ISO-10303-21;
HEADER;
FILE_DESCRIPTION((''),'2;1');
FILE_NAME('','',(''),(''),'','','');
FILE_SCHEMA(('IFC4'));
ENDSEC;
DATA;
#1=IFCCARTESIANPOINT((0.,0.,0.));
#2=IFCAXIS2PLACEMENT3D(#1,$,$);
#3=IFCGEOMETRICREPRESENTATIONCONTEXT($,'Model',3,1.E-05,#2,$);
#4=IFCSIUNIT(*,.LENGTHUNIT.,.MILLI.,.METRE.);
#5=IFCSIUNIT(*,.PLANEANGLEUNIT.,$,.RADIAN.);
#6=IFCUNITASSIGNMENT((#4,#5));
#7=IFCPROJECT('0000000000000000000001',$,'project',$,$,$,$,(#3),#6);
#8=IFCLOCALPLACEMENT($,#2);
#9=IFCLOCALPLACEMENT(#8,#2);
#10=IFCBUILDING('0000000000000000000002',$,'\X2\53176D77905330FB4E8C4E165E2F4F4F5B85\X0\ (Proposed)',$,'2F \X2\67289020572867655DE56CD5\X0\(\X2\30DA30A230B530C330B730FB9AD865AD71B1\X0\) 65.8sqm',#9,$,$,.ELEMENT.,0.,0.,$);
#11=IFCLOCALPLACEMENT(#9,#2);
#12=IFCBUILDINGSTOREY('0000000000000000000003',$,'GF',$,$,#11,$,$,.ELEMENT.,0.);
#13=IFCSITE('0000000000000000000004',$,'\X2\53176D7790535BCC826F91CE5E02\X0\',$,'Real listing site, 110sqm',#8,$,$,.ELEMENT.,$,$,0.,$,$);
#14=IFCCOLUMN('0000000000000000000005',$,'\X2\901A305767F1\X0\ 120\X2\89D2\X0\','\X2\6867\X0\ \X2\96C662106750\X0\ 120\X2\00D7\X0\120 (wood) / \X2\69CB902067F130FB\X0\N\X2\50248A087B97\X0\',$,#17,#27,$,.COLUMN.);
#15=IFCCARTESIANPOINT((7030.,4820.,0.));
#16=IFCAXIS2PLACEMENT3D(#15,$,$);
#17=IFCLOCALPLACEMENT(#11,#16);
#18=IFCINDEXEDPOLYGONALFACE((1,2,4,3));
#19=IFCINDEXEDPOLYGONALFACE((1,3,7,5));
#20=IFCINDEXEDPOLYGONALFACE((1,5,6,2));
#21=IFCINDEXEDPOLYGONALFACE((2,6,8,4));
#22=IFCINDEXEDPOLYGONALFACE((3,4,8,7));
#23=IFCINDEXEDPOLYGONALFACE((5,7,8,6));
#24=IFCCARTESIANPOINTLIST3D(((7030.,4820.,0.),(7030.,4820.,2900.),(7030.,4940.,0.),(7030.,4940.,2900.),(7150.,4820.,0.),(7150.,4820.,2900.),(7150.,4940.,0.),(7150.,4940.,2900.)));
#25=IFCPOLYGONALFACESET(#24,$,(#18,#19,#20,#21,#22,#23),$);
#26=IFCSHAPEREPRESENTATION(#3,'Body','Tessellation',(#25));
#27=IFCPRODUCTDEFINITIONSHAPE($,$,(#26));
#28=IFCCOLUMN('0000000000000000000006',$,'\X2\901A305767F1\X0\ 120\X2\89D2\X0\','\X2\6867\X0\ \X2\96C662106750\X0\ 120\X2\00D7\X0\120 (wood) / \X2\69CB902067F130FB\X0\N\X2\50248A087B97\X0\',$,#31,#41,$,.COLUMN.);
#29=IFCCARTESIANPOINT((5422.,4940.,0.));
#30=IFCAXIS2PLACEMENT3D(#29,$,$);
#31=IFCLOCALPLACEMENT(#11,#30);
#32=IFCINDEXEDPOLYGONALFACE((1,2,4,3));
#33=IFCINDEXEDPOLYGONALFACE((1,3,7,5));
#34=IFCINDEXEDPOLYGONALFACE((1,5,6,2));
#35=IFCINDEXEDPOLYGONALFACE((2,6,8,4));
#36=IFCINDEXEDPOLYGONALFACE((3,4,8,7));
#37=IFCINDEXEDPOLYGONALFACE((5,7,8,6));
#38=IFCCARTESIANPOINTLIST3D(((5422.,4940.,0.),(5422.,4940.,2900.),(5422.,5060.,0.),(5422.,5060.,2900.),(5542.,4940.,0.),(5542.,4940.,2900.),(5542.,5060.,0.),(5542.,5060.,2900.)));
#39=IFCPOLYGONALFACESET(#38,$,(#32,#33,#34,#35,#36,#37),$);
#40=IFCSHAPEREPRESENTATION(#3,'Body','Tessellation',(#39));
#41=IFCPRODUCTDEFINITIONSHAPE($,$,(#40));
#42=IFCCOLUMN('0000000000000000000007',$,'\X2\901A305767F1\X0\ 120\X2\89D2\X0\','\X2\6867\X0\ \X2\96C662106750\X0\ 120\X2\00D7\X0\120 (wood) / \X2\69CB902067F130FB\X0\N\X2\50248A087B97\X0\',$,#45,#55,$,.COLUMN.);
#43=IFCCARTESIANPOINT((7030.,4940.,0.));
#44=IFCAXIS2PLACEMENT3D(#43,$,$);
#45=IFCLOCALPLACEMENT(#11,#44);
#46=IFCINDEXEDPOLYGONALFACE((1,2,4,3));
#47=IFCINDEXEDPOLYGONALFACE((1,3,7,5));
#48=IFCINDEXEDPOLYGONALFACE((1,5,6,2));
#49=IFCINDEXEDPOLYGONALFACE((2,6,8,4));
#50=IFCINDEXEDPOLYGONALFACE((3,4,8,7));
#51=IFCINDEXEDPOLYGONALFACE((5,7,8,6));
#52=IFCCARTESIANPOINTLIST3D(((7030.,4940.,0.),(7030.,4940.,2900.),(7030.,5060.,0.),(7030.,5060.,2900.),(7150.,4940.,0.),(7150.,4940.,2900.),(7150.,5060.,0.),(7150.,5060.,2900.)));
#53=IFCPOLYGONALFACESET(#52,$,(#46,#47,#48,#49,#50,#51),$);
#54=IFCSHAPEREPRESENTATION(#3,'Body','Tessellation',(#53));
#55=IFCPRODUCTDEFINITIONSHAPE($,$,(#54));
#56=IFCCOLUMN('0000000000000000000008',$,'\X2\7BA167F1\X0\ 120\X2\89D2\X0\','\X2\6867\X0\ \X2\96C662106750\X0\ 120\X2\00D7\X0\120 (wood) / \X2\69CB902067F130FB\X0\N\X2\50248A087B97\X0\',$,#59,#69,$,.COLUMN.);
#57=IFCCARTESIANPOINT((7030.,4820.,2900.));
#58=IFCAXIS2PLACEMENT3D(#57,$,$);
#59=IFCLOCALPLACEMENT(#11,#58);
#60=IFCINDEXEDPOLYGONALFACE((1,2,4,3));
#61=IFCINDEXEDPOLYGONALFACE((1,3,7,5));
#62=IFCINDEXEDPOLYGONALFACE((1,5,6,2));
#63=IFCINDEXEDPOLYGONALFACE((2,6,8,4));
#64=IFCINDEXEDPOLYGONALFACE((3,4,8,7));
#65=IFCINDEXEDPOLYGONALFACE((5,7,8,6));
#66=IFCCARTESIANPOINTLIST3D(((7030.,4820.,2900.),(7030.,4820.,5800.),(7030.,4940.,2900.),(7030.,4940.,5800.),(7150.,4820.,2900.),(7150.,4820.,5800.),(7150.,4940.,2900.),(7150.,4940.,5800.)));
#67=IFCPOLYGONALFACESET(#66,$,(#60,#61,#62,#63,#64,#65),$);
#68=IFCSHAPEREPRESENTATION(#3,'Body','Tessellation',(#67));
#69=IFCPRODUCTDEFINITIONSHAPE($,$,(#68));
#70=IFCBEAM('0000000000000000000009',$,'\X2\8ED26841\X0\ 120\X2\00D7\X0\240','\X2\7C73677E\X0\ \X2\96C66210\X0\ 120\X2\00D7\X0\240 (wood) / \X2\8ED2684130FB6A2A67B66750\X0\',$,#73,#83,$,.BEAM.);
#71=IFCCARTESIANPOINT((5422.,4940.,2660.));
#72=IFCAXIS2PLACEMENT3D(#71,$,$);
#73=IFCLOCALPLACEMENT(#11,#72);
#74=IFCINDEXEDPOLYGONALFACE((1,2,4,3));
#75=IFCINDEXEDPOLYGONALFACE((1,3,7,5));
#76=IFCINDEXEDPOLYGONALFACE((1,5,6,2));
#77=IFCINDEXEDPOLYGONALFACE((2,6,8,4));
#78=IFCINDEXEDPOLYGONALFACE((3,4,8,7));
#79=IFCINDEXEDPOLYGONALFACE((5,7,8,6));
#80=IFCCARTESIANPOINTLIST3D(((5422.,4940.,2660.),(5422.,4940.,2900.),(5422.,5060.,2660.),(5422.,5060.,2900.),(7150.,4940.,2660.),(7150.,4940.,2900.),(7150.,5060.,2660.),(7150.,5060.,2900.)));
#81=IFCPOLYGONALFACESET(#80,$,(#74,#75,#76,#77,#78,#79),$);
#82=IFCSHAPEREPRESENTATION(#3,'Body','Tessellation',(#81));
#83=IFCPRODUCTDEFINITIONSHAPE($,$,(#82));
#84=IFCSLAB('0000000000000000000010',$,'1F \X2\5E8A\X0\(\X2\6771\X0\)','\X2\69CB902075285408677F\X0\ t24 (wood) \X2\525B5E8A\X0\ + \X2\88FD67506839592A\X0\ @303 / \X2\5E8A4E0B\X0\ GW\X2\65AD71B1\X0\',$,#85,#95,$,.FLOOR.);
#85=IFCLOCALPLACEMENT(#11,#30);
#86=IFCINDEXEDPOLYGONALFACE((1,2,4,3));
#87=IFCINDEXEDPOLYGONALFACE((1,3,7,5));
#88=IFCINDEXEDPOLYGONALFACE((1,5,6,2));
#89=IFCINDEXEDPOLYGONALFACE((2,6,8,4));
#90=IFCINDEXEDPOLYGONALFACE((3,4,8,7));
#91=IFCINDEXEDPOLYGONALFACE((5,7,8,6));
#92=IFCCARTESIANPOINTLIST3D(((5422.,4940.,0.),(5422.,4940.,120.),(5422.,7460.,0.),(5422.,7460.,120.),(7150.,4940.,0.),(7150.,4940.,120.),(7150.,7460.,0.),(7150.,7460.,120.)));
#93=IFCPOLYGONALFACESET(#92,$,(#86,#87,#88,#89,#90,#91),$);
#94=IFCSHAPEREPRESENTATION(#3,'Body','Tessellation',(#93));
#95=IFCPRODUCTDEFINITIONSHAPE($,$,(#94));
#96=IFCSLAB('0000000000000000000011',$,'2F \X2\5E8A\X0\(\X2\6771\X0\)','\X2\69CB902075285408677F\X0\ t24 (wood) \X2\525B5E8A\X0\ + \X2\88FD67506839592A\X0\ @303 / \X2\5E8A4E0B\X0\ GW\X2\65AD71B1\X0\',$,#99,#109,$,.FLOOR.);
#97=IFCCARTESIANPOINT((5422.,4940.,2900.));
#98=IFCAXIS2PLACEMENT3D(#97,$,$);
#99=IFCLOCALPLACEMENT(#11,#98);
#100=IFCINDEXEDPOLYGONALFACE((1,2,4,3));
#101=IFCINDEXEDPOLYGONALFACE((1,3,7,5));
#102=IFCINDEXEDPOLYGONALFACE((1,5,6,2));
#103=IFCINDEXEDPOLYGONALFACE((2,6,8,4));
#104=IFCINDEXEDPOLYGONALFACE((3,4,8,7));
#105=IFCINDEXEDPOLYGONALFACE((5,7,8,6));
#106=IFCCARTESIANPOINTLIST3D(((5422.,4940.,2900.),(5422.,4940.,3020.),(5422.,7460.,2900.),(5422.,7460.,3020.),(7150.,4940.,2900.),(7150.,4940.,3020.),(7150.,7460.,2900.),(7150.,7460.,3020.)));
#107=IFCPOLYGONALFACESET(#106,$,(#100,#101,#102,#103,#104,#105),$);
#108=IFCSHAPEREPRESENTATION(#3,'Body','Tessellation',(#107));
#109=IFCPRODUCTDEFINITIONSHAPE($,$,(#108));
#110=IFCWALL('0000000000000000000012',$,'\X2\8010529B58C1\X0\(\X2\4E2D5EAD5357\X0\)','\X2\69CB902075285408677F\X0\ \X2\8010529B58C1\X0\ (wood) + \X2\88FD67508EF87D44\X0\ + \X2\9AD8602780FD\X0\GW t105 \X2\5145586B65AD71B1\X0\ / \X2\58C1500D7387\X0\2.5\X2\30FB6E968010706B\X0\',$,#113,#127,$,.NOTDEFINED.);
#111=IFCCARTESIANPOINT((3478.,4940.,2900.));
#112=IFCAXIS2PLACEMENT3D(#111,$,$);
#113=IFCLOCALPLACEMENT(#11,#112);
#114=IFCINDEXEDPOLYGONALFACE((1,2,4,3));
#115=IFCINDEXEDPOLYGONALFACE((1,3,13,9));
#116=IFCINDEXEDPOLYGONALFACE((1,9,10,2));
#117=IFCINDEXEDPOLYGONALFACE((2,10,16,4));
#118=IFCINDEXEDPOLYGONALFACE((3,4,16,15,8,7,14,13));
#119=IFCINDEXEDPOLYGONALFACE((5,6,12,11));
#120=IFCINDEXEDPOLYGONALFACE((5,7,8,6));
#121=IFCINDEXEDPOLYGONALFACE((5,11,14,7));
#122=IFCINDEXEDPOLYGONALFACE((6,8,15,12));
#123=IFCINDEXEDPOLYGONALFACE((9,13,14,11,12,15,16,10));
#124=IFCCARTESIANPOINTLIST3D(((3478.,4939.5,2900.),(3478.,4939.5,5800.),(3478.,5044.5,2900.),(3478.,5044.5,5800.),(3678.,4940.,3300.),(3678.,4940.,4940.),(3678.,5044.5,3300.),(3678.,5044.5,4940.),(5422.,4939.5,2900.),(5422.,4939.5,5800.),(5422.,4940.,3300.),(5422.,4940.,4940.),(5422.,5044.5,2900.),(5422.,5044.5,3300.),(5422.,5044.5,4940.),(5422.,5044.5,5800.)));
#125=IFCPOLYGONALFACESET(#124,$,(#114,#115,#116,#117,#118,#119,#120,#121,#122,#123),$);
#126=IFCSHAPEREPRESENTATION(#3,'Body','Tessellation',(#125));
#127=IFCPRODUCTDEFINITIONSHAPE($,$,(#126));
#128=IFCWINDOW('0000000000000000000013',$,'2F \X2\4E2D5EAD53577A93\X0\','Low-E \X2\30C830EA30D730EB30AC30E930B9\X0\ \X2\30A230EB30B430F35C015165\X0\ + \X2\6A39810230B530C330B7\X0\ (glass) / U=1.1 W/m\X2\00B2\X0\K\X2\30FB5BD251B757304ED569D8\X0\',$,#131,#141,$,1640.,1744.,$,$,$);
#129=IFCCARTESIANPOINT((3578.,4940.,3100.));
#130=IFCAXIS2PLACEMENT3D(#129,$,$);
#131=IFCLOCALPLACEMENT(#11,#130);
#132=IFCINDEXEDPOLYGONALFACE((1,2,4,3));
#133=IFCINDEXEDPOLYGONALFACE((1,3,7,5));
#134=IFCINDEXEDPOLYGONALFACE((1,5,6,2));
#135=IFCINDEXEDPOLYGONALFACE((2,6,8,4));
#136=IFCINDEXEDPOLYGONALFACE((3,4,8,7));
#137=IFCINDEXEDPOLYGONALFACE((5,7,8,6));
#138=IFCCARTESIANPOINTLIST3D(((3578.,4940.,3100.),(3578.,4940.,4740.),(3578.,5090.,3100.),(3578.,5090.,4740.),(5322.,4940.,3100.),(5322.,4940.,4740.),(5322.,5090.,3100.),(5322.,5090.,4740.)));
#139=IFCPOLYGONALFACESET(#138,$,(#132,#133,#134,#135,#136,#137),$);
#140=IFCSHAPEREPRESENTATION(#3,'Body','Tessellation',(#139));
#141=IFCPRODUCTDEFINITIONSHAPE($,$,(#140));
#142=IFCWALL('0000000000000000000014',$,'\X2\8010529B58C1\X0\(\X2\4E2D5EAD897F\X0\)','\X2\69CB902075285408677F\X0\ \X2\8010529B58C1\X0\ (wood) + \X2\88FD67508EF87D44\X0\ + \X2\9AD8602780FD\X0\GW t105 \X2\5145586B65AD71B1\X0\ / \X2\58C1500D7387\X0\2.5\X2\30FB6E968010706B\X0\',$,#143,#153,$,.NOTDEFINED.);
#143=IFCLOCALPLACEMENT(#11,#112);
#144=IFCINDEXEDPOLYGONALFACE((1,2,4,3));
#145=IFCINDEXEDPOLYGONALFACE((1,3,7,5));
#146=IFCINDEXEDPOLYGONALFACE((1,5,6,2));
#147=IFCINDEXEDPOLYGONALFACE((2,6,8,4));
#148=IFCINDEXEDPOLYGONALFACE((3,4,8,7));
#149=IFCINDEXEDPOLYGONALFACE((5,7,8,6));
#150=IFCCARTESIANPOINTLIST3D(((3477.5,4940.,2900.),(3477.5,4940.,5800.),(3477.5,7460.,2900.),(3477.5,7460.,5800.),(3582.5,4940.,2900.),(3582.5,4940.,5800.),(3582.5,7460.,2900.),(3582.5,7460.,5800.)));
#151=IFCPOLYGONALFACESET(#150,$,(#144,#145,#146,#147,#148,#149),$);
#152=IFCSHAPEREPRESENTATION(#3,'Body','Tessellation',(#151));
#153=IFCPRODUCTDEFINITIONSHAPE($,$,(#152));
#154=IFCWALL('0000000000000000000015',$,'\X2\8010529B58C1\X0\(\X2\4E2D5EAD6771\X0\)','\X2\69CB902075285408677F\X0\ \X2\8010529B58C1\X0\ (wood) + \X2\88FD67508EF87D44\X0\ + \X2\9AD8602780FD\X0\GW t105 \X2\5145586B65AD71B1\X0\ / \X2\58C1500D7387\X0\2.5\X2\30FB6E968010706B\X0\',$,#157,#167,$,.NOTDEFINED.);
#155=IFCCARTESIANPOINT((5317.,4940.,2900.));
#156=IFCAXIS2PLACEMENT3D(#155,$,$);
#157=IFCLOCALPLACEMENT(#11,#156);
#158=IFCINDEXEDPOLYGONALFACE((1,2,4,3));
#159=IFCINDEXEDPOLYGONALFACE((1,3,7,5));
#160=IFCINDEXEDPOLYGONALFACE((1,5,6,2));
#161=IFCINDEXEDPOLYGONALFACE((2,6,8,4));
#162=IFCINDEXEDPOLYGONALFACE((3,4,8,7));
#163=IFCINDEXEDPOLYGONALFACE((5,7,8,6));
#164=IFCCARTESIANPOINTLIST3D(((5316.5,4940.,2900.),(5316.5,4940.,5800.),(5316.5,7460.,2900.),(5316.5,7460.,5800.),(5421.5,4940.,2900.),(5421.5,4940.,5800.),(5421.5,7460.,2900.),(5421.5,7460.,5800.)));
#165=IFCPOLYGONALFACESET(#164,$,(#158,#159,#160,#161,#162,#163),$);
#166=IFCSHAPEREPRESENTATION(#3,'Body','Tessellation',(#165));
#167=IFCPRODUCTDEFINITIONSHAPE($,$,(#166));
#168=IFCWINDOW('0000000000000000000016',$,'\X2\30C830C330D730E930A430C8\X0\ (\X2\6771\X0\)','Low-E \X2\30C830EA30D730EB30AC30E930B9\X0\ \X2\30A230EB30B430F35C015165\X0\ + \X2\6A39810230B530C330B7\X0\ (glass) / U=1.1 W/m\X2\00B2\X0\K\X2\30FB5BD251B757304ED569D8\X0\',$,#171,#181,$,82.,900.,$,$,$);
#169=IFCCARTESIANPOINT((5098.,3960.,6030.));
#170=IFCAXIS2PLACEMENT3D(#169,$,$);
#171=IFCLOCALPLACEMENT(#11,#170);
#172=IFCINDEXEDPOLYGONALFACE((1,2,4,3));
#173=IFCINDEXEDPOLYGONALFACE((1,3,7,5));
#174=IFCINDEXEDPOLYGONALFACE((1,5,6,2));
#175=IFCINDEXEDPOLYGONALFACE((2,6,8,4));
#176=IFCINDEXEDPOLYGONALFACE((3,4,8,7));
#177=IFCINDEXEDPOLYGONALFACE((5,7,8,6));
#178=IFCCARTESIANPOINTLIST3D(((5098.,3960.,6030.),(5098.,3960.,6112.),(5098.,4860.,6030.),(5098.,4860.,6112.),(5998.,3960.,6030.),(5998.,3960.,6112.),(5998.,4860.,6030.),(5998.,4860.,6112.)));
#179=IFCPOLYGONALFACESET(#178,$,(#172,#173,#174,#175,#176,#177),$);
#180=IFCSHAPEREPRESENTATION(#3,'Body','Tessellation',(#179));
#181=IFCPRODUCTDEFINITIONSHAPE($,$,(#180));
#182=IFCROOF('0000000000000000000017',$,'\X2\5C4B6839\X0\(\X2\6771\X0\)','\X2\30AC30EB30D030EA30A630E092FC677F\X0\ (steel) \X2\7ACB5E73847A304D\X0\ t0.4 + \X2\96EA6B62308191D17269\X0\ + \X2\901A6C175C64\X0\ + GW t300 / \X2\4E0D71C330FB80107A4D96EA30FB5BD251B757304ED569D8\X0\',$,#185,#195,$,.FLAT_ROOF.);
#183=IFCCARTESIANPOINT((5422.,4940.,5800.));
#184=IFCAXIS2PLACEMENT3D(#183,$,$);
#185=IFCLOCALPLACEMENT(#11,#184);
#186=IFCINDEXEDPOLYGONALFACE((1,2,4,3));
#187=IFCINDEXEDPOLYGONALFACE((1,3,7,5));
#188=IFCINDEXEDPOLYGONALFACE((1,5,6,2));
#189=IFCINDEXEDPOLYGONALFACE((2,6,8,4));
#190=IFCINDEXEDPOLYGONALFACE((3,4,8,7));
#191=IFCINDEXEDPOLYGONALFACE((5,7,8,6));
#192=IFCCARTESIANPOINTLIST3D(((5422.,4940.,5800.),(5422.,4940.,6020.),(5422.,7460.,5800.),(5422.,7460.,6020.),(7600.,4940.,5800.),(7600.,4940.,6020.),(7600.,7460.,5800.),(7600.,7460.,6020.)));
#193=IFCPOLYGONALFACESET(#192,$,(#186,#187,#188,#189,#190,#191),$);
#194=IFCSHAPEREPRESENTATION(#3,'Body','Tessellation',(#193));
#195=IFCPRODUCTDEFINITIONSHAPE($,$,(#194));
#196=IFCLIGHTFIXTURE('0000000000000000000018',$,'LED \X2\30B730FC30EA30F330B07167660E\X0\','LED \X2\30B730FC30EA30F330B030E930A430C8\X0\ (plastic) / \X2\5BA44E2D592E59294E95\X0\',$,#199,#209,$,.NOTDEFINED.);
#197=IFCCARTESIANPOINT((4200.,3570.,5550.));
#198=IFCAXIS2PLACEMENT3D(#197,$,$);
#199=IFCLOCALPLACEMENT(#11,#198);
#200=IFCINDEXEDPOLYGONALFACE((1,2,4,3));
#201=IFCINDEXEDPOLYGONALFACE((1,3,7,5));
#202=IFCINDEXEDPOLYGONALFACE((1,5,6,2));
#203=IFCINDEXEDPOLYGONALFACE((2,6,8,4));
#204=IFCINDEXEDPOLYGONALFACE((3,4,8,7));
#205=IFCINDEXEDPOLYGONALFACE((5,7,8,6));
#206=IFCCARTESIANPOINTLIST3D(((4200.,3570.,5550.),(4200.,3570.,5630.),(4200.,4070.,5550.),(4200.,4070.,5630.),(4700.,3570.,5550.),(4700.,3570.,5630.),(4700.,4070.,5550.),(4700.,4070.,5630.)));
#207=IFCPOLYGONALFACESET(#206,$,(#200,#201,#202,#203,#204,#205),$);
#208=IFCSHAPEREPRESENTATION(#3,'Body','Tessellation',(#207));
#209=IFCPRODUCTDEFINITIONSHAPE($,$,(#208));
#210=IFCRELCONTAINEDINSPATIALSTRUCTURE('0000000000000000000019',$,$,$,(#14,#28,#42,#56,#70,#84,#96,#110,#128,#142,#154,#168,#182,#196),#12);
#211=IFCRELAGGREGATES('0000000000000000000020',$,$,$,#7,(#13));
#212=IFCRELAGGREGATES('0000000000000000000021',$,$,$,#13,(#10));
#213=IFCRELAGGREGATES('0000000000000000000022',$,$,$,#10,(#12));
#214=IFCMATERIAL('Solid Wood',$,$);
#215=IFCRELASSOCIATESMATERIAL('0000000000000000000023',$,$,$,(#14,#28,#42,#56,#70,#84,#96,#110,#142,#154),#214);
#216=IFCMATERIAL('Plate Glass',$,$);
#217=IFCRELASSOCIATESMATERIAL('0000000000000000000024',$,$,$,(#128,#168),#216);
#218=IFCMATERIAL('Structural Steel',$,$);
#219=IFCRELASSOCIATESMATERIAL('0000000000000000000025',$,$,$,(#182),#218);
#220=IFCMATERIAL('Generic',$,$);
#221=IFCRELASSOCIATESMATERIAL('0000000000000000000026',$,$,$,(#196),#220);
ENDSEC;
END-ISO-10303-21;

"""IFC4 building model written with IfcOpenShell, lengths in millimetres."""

from ifc_helpers import new_model, si_unit, frame, frame_2d, origin, place, context, project, spatial, rectangle, extrude, material, element, fill, save


model = new_model("IFC4")

# Units and contexts
model_context = context("Model", 3, precision=1e-05, world=origin())
ifc_project = project(units=[si_unit("LENGTHUNIT", "METRE", prefix="MILLI"), si_unit("PLANEANGLEUNIT", "RADIAN")], contexts=[model_context])

# Site, building, storey
site_placement = place(None, origin())
site = spatial("IfcSite", under=ifc_project, at=site_placement, Name="北海道富良野市", ObjectType="Real listing site, 110sqm", CompositionType="ELEMENT", RefElevation=0.0)
building_placement = place(site_placement, origin())
building = spatial("IfcBuilding", under=site, at=building_placement, Name="北海道・二世帯住宅 (Proposed)", ObjectType="2F 木造在来工法(ペアサッシ・高断熱) 65.8sqm", CompositionType="ELEMENT", ElevationOfRefHeight=0.0, ElevationOfTerrain=0.0)
storey_placement = place(building_placement, origin())
storey = spatial("IfcBuildingStorey", under=building, at=storey_placement, Name="GF", CompositionType="ELEMENT", Elevation=0.0)

# Columns
ifc_material_1 = material(Name="Solid Wood")
column_1_placement = place(storey_placement, frame((7030.0, 4820.0, 0.0)))
element("IfcColumn", 1, at=column_1_placement, inside=storey, material=ifc_material_1, Name="通し柱 120角", Description="桧 集成材 120×120 (wood) / 構造柱・N値計算", PredefinedType="COLUMN", context=model_context, shape_type="SweptSolid", body=[
    extrude(rectangle(XDim=120.0, YDim=120.0, at=frame_2d((60.0, 60.0))), frame((7030.0, 4820.0, 0.0)), (0.0, 0.0, 1.0), 2900.0),
])
column_2_placement = place(storey_placement, frame((5422.0, 4940.0, 0.0)))
element("IfcColumn", 2, at=column_2_placement, inside=storey, material=ifc_material_1, Name="通し柱 120角", Description="桧 集成材 120×120 (wood) / 構造柱・N値計算", PredefinedType="COLUMN", context=model_context, shape_type="SweptSolid", body=[
    extrude(rectangle(XDim=120.0, YDim=120.0, at=frame_2d((60.0, 60.0))), frame((5422.0, 4940.0, 0.0)), (0.0, 0.0, 1.0), 2900.0),
])
column_3_placement = place(storey_placement, frame((7030.0, 4940.0, 0.0)))
element("IfcColumn", 3, at=column_3_placement, inside=storey, material=ifc_material_1, Name="通し柱 120角", Description="桧 集成材 120×120 (wood) / 構造柱・N値計算", PredefinedType="COLUMN", context=model_context, shape_type="SweptSolid", body=[
    extrude(rectangle(XDim=120.0, YDim=120.0, at=frame_2d((60.0, 60.0))), frame((7030.0, 4940.0, 0.0)), (0.0, 0.0, 1.0), 2900.0),
])
column_4_placement = place(storey_placement, frame((7030.0, 4820.0, 2900.0)))
element("IfcColumn", 4, at=column_4_placement, inside=storey, material=ifc_material_1, Name="管柱 120角", Description="桧 集成材 120×120 (wood) / 構造柱・N値計算", PredefinedType="COLUMN", context=model_context, shape_type="SweptSolid", body=[
    extrude(rectangle(XDim=120.0, YDim=120.0, at=frame_2d((60.0, 60.0))), frame((7030.0, 4820.0, 2900.0)), (0.0, 0.0, 1.0), 2900.0),
])

# Beam
beam_1_placement = place(storey_placement, frame((5422.0, 4940.0, 2660.0)))
element("IfcBeam", 5, at=beam_1_placement, inside=storey, material=ifc_material_1, Name="軒桁 120×240", Description="米松 集成 120×240 (wood) / 軒桁・横架材", PredefinedType="BEAM", context=model_context, shape_type="SweptSolid", body=[
    extrude(rectangle(XDim=1728.0, YDim=120.0, at=frame_2d((864.0, 60.0))), frame((5422.0, 4940.0, 2660.0)), (0.0, 0.0, 1.0), 240.0),
])

# Slabs
slab_1_placement = place(storey_placement, frame((5422.0, 4940.0, 0.0)))
element("IfcSlab", 6, at=slab_1_placement, inside=storey, material=ifc_material_1, Name="1F 床(東)", Description="構造用合板 t24 (wood) 剛床 + 製材根太 @303 / 床下 GW断熱", PredefinedType="FLOOR", context=model_context, shape_type="SweptSolid", body=[
    extrude(rectangle(XDim=1728.0, YDim=2520.0, at=frame_2d((864.0, 1260.0))), frame((5422.0, 4940.0, 0.0)), (0.0, 0.0, 1.0), 120.0),
])
slab_2_placement = place(storey_placement, frame((5422.0, 4940.0, 2900.0)))
element("IfcSlab", 7, at=slab_2_placement, inside=storey, material=ifc_material_1, Name="2F 床(東)", Description="構造用合板 t24 (wood) 剛床 + 製材根太 @303 / 床下 GW断熱", PredefinedType="FLOOR", context=model_context, shape_type="SweptSolid", body=[
    extrude(rectangle(XDim=1728.0, YDim=2520.0, at=frame_2d((864.0, 1260.0))), frame((5422.0, 4940.0, 2900.0)), (0.0, 0.0, 1.0), 120.0),
])

# Wall, opening, window
wall_1_placement = place(storey_placement, frame((3478.0, 4940.0, 2900.0)))
wall_1 = element("IfcWall", 8, at=wall_1_placement, inside=storey, material=ifc_material_1, Name="耐力壁(中庭南)", Description="構造用合板 耐力壁 (wood) + 製材軸組 + 高性能GW t105 充填断熱 / 壁倍率2.5・準耐火", PredefinedType="NOTDEFINED", context=model_context, shape_type="SweptSolid", body=[
    extrude(rectangle(XDim=1944.0, YDim=105.0, at=frame_2d((972.0, 52.0))), frame((3478.0, 4940.0, 2900.0)), (0.0, 0.0, 1.0), 2900.0),
])
opening_placement = place(storey_placement, frame((3578.0, 4940.0, 3100.0)))
opening = element("IfcOpeningElement", 9, at=opening_placement, cuts=wall_1, PredefinedType="NOTDEFINED", context=model_context, shape_type="SweptSolid", body=[
    extrude(rectangle(XDim=1744.0, YDim=150.0, at=frame_2d((872.0, 75.0))), frame((3578.0, 4940.0, 3100.0)), (0.0, 0.0, 1.0), 1640.0),
])
ifc_material_2 = material(Name="Plate Glass")
window_1_placement = place(storey_placement, frame((3578.0, 4940.0, 3100.0)))
window_1 = element("IfcWindow", 10, at=window_1_placement, inside=storey, material=ifc_material_2, Name="2F 中庭南窓", Description="Low-E トリプルガラス アルゴン封入 + 樹脂サッシ (glass) / U=1.1 W/m²K・寒冷地仕様", OverallHeight=1640.0, OverallWidth=1744.0, context=model_context, shape_type="SweptSolid", body=[
    extrude(rectangle(XDim=1744.0, YDim=150.0, at=frame_2d((872.0, 75.0))), frame((3578.0, 4940.0, 3100.0)), (0.0, 0.0, 1.0), 1640.0),
])
fill(opening, window_1)

# Walls
wall_2_placement = place(storey_placement, frame((3478.0, 4940.0, 2900.0)))
element("IfcWall", 11, at=wall_2_placement, inside=storey, material=ifc_material_1, Name="耐力壁(中庭西)", Description="構造用合板 耐力壁 (wood) + 製材軸組 + 高性能GW t105 充填断熱 / 壁倍率2.5・準耐火", PredefinedType="NOTDEFINED", context=model_context, shape_type="SweptSolid", body=[
    extrude(rectangle(XDim=105.0, YDim=2520.0, at=frame_2d((52.0, 1260.0))), frame((3478.0, 4940.0, 2900.0)), (0.0, 0.0, 1.0), 2900.0),
])
wall_3_placement = place(storey_placement, frame((5317.0, 4940.0, 2900.0)))
element("IfcWall", 12, at=wall_3_placement, inside=storey, material=ifc_material_1, Name="耐力壁(中庭東)", Description="構造用合板 耐力壁 (wood) + 製材軸組 + 高性能GW t105 充填断熱 / 壁倍率2.5・準耐火", PredefinedType="NOTDEFINED", context=model_context, shape_type="SweptSolid", body=[
    extrude(rectangle(XDim=105.0, YDim=2520.0, at=frame_2d((52.0, 1260.0))), frame((5317.0, 4940.0, 2900.0)), (0.0, 0.0, 1.0), 2900.0),
])

# Window
window_2_placement = place(storey_placement, frame((5098.0, 3960.0, 6030.0)))
element("IfcWindow", 13, at=window_2_placement, inside=storey, material=ifc_material_2, Name="トップライト (東)", Description="Low-E トリプルガラス アルゴン封入 + 樹脂サッシ (glass) / U=1.1 W/m²K・寒冷地仕様", OverallHeight=82.0, OverallWidth=900.0, context=model_context, shape_type="SweptSolid", body=[
    extrude(rectangle(XDim=900.0, YDim=900.0, at=frame_2d((450.0, 450.0))), frame((5098.0, 3960.0, 6030.0)), (0.0, 0.0, 1.0), 82.0),
])

# Roof
ifc_material_3 = material(Name="Structural Steel")
for number, where, name in (
    (14, (5422.0, 4940.0, 5800.0), "屋根(東)"),
):
    element("IfcRoof", number, at=place(storey_placement, frame(where)), inside=storey, material=ifc_material_3, Name=name, Description="ガルバリウム鋼板 (steel) 立平葺き t0.4 + 雪止め金物 + 通気層 + GW t300 / 不燃・耐積雪・寒冷地仕様", PredefinedType="FLAT_ROOF", context=model_context, shape_type="SweptSolid", body=[
        extrude(rectangle(XDim=2178.0, YDim=2520.0, at=frame_2d((1089.0, 1260.0))), frame((5422.0, 4940.0, 5800.0)), (0.0, 0.0, 1.0), 220.0),
    ])

# Light fixture
ifc_material_4 = material(Name="Generic")
light_fixture_placement = place(storey_placement, frame((4200.0, 3570.0, 5550.0)))
element("IfcLightFixture", 15, at=light_fixture_placement, inside=storey, material=ifc_material_4, Name="LED シーリング照明", Description="LED シーリングライト (plastic) / 室中央天井", PredefinedType="NOTDEFINED", context=model_context, shape_type="SweptSolid", body=[
    extrude(rectangle(XDim=500.0, YDim=500.0, at=frame_2d((250.0, 250.0))), frame((4200.0, 3570.0, 5550.0)), (0.0, 0.0, 1.0), 80.0),
])

save(model, "model.ifc")
